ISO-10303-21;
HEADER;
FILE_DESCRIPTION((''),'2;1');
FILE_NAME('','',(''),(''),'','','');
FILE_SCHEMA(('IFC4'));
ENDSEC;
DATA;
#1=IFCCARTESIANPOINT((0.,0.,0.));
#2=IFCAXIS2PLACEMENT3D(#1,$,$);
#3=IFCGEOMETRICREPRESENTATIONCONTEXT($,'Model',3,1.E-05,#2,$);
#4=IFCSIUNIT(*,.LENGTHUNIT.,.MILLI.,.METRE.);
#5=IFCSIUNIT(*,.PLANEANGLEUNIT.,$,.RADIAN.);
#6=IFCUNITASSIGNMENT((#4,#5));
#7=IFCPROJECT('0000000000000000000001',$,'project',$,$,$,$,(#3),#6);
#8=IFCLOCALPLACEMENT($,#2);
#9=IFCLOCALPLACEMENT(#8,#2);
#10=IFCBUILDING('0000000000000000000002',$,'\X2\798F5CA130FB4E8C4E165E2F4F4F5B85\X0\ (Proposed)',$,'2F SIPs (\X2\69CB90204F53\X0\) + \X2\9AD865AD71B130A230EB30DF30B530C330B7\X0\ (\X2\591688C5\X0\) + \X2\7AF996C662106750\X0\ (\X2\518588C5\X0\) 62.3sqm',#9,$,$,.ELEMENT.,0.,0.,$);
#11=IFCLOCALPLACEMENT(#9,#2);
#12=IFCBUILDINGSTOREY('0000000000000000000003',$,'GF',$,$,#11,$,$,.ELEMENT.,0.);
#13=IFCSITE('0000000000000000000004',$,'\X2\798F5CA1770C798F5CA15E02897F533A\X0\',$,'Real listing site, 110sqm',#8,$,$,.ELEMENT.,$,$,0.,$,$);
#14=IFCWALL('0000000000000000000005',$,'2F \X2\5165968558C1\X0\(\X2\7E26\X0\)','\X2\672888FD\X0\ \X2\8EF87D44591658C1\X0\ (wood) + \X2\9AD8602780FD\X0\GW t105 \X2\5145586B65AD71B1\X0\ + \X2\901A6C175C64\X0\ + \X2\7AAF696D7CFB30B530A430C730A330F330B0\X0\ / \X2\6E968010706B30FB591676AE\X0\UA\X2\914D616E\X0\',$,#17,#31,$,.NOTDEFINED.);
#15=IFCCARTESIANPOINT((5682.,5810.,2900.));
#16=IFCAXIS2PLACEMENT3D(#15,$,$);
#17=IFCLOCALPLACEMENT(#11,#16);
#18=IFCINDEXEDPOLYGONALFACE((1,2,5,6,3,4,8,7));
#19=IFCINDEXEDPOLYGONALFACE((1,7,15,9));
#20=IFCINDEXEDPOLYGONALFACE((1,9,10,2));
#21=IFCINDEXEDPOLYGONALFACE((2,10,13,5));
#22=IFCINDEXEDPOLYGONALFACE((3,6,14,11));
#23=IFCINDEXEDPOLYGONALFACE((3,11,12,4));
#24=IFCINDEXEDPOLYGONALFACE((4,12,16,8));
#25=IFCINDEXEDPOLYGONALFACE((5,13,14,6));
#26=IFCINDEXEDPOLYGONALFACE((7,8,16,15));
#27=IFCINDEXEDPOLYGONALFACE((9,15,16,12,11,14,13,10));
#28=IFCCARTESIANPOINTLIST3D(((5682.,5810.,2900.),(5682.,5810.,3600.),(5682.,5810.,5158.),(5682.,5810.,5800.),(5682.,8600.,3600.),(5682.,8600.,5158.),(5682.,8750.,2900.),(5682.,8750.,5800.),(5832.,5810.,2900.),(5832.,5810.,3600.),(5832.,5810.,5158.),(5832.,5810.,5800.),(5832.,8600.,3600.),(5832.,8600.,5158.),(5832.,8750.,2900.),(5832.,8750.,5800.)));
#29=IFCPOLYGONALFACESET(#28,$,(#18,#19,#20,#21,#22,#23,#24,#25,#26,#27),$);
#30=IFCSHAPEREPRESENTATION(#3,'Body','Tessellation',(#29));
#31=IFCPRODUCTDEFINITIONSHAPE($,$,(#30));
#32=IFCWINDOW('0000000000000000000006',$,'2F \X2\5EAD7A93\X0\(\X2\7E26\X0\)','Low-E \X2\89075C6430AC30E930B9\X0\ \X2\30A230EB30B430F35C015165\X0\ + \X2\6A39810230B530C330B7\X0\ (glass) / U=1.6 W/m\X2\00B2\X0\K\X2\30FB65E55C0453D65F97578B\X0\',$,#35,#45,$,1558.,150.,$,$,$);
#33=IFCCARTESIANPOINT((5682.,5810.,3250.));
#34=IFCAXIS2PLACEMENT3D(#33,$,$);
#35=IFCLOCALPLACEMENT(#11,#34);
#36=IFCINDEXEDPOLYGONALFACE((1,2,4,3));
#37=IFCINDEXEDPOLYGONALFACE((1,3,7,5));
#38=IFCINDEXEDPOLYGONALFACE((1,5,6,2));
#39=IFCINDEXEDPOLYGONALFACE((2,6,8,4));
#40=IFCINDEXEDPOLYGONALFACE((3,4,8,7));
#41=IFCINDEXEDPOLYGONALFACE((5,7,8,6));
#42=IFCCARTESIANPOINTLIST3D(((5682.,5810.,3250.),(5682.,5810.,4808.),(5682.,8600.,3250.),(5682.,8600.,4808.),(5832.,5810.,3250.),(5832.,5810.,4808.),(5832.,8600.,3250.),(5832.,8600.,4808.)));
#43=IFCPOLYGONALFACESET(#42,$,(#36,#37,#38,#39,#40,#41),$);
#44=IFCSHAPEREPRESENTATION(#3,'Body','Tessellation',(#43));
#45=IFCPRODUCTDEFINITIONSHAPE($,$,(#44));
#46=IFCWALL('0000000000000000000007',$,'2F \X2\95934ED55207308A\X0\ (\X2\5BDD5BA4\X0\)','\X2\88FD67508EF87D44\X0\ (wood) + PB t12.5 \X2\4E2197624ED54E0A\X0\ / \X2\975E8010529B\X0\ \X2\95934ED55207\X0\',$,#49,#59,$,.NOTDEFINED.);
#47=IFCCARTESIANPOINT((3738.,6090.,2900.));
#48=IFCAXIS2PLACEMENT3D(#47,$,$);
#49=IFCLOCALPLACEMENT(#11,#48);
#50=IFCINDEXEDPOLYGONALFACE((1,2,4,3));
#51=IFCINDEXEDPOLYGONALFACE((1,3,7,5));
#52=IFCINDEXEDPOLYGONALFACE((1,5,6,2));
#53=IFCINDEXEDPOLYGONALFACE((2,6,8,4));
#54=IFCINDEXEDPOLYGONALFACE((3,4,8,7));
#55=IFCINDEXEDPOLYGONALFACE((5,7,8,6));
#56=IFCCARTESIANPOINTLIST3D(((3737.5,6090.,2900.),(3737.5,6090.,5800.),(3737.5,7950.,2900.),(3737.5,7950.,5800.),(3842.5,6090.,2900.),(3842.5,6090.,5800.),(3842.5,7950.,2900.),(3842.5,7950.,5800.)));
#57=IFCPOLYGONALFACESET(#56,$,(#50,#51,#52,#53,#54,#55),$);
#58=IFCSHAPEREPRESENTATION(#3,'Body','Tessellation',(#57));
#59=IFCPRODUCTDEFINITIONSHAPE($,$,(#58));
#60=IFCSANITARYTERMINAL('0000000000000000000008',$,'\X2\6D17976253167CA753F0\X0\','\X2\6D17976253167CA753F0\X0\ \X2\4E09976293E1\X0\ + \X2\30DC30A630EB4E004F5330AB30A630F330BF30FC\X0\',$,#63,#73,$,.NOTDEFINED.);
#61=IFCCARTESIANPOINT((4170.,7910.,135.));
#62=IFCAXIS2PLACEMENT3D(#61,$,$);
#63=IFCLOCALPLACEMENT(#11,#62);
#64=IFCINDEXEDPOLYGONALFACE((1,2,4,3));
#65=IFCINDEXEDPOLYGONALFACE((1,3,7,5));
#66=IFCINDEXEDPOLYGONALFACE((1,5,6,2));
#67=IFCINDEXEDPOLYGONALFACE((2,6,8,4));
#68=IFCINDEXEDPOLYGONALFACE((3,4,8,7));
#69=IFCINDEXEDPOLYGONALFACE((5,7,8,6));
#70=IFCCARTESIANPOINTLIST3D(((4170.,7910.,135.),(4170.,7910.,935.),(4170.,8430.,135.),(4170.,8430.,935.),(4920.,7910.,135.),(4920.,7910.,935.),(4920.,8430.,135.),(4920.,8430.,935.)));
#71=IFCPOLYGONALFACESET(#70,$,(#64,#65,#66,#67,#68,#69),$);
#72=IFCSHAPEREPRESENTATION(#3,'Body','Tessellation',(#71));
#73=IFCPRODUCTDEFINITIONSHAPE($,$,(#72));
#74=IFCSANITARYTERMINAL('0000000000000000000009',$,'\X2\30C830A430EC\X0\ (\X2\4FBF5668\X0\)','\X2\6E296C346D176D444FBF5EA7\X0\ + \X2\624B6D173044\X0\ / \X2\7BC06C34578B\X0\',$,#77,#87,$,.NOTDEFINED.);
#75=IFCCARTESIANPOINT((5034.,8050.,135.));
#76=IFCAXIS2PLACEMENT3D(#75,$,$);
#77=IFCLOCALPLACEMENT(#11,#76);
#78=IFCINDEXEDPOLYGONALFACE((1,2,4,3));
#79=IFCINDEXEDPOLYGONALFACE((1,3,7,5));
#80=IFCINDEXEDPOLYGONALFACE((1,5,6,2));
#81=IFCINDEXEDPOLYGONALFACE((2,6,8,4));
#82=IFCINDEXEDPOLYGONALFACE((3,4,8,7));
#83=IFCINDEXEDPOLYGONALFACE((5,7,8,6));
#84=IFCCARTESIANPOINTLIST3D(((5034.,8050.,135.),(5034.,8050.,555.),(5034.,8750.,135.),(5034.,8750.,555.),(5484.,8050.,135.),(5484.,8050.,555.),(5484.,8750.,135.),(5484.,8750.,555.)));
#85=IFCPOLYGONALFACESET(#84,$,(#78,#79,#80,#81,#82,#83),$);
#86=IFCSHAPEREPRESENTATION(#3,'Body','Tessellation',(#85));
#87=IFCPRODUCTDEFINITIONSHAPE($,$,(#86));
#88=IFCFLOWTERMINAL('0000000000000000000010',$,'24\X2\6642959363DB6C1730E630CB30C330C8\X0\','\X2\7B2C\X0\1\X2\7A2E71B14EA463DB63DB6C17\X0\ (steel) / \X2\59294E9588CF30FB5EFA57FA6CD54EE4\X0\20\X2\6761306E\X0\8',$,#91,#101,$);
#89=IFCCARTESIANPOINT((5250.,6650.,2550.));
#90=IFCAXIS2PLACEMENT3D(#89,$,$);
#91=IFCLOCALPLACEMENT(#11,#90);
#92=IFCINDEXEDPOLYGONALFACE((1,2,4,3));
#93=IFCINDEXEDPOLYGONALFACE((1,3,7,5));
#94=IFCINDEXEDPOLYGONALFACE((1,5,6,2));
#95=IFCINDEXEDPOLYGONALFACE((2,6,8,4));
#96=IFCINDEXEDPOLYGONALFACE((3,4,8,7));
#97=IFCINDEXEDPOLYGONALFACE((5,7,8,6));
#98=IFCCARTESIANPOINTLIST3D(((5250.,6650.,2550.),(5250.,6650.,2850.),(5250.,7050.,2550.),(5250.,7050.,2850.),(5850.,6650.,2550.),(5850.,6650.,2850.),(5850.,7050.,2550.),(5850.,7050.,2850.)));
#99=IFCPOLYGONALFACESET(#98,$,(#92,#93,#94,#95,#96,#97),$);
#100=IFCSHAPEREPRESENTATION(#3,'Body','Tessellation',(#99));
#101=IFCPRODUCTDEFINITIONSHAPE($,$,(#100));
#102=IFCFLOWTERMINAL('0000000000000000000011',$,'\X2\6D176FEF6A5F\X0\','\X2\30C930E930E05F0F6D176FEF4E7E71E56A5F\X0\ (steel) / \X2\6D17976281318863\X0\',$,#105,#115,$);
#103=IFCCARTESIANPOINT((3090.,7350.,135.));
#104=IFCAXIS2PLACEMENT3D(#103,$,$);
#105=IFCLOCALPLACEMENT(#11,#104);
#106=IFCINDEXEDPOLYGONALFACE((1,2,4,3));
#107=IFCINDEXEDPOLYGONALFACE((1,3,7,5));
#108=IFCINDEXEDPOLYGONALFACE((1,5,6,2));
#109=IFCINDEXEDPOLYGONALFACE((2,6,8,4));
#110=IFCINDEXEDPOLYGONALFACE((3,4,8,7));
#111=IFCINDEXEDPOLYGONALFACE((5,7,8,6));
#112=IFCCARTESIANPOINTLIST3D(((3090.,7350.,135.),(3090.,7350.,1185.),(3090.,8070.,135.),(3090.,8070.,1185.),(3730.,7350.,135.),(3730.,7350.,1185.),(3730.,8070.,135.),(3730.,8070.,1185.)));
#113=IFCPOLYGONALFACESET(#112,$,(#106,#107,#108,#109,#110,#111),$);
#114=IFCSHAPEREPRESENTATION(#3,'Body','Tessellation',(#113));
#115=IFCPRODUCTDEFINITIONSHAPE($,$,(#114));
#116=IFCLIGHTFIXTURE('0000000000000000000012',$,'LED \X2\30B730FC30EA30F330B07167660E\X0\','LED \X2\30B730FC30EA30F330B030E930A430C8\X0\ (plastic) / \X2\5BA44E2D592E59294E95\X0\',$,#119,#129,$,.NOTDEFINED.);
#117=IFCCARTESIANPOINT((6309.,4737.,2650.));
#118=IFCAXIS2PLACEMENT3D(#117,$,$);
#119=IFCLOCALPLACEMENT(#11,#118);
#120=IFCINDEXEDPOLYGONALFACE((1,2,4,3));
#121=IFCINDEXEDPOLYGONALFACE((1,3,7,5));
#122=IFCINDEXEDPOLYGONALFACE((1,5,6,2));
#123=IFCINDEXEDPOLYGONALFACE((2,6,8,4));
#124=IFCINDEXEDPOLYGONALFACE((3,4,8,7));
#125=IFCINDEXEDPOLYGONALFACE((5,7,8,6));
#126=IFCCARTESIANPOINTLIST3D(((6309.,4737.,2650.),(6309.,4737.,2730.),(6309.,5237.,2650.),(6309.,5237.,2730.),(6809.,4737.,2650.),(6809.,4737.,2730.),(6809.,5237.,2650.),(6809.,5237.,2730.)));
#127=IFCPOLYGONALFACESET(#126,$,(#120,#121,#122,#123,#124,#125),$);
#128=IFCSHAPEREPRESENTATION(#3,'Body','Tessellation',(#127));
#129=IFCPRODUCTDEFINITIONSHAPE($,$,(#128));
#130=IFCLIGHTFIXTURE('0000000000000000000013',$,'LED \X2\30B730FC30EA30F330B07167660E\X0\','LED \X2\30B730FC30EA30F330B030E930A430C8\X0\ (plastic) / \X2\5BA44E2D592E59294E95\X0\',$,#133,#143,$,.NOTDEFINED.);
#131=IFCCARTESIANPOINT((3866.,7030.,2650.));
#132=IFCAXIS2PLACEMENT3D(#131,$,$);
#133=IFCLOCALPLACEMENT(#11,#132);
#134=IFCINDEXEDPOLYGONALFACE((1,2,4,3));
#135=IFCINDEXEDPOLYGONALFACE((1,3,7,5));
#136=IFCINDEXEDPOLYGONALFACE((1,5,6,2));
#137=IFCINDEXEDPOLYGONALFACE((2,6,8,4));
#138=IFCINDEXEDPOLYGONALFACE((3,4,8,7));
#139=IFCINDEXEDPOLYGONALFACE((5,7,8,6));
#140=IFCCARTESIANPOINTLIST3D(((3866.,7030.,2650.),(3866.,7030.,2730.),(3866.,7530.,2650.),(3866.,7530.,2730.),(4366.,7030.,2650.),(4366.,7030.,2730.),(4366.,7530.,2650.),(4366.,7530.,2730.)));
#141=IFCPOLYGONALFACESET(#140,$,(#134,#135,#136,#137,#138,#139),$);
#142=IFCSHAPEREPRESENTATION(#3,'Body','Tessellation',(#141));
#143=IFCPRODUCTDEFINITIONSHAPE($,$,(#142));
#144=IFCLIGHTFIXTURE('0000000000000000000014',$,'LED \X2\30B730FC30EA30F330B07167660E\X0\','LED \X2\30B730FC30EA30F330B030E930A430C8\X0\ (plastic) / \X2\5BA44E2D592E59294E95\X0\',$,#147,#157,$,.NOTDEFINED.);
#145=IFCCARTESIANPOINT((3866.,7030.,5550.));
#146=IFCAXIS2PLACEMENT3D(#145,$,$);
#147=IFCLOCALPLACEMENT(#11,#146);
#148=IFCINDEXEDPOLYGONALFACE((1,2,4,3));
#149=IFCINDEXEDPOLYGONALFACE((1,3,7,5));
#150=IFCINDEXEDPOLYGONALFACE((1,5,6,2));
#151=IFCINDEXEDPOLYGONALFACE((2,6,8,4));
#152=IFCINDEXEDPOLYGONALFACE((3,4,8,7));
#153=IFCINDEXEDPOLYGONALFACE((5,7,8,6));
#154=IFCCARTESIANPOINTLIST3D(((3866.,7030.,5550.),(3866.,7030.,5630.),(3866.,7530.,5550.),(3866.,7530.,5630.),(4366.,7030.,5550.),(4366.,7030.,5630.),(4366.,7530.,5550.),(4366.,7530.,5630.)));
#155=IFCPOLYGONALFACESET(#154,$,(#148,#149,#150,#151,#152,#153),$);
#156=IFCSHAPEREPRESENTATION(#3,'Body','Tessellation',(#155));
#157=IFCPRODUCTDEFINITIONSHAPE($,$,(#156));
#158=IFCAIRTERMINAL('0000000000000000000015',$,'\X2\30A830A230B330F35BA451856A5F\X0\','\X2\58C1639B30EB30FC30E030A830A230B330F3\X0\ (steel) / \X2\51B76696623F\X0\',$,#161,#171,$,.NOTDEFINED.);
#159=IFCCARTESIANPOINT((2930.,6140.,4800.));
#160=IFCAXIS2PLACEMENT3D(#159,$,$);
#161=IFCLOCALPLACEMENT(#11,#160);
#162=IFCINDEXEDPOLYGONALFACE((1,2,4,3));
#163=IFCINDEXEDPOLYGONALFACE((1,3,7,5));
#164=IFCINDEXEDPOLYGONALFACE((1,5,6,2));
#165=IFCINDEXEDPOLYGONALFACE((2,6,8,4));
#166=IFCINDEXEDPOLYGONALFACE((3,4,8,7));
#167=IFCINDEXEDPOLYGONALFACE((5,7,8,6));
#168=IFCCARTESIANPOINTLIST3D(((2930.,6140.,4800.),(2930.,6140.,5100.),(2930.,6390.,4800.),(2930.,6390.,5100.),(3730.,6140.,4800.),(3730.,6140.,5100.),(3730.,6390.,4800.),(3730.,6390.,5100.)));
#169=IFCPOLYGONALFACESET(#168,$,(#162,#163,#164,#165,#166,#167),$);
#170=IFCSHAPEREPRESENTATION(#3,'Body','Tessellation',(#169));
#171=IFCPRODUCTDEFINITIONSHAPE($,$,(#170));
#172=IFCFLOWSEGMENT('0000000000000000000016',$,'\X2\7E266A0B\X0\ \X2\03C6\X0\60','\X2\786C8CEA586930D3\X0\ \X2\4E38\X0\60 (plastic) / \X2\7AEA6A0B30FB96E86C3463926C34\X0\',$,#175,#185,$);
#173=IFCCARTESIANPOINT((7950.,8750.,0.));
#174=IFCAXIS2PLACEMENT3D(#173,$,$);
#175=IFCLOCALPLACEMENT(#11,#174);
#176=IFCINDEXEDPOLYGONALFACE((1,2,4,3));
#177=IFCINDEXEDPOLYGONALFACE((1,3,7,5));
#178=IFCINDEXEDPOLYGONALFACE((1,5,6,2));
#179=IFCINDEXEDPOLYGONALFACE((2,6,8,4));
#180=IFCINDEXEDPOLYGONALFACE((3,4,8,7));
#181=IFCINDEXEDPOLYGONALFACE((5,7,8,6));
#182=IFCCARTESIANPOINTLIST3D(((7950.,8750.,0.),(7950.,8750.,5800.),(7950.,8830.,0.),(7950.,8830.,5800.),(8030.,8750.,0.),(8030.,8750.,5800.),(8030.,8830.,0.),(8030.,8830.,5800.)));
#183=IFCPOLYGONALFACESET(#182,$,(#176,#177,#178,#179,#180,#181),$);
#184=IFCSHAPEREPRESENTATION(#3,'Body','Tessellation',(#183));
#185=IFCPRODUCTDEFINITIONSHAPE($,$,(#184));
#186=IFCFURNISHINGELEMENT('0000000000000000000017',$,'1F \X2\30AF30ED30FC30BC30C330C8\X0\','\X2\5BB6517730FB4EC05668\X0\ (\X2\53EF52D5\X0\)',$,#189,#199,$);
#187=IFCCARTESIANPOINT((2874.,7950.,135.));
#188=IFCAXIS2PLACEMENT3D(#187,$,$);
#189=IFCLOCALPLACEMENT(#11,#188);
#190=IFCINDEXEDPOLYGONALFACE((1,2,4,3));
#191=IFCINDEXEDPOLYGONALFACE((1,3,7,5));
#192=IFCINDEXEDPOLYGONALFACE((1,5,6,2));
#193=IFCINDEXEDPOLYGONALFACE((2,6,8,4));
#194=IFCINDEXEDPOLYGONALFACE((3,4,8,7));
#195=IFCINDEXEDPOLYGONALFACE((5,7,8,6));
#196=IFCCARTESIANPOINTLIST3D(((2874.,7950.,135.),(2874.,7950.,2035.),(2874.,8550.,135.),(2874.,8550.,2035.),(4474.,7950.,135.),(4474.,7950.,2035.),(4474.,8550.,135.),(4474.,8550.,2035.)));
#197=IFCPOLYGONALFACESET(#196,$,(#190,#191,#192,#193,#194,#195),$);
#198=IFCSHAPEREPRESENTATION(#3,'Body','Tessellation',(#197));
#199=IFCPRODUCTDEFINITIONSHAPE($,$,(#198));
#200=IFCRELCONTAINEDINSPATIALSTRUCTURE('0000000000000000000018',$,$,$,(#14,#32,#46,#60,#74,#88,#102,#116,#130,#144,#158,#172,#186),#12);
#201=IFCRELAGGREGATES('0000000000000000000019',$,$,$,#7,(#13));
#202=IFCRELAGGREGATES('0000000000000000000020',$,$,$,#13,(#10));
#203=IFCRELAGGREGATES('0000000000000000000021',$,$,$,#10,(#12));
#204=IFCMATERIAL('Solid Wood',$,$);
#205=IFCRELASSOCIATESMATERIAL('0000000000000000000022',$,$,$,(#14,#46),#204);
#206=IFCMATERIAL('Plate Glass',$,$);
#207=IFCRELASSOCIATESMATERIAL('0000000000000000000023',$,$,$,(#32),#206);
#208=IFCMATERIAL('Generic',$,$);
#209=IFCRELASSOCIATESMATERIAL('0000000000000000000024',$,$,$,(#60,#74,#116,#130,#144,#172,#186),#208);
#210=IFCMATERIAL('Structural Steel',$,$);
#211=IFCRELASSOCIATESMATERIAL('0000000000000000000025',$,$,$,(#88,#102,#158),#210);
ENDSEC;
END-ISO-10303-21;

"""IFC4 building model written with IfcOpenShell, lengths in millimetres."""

from ifc_helpers import new_model, si_unit, frame, frame_2d, origin, place, context, project, spatial, rectangle, extrude, material, element, fill, save


model = new_model("IFC4")

# Units and contexts
model_context = context("Model", 3, precision=1e-05, world=origin())
ifc_project = project(units=[si_unit("LENGTHUNIT", "METRE", prefix="MILLI"), si_unit("PLANEANGLEUNIT", "RADIAN")], contexts=[model_context])

# Site, building, storey
site_placement = place(None, origin())
site = spatial("IfcSite", under=ifc_project, at=site_placement, Name="福岡県福岡市西区", ObjectType="Real listing site, 110sqm", CompositionType="ELEMENT", RefElevation=0.0)
building_placement = place(site_placement, origin())
building = spatial("IfcBuilding", under=site, at=building_placement, Name="福岡・二世帯住宅 (Proposed)", ObjectType="2F SIPs (構造体) + 高断熱アルミサッシ (外装) + 竹集成材 (内装) 62.3sqm", CompositionType="ELEMENT", ElevationOfRefHeight=0.0, ElevationOfTerrain=0.0)
storey_placement = place(building_placement, origin())
storey = spatial("IfcBuildingStorey", under=building, at=storey_placement, Name="GF", CompositionType="ELEMENT", Elevation=0.0)

# Shared definitions
ifc_material_1 = material(Name="Solid Wood")

# Shared definitions
ifc_material_2 = material(Name="Plate Glass")

# Wall, opening, window
wall_1_placement = place(storey_placement, frame((5682.0, 5810.0, 2900.0)))
wall_1 = element("IfcWall", 1, at=wall_1_placement, inside=storey, material=ifc_material_1, Name="2F 入隅壁(縦)", Description="木製 軸組外壁 (wood) + 高性能GW t105 充填断熱 + 通気層 + 窯業系サイディング / 準耐火・外皮UA配慮", PredefinedType="NOTDEFINED", context=model_context, shape_type="SweptSolid", body=[
    extrude(rectangle(XDim=150.0, YDim=2940.0, at=frame_2d((75.0, 1470.0))), frame((5682.0, 5810.0, 2900.0)), (0.0, 0.0, 1.0), 2900.0),
])
opening_1_placement = place(storey_placement, frame((5682.0, 5810.0, 3250.0)))
opening_1 = element("IfcOpeningElement", 2, at=opening_1_placement, cuts=wall_1, PredefinedType="NOTDEFINED", context=model_context, shape_type="SweptSolid", body=[
    extrude(rectangle(XDim=150.0, YDim=2790.0, at=frame_2d((75.0, 1395.0))), frame((5682.0, 5810.0, 3250.0)), (0.0, 0.0, 1.0), 1558.0),
])
window_1_placement = place(storey_placement, frame((5682.0, 5810.0, 3250.0)))
window_1 = element("IfcWindow", 3, at=window_1_placement, inside=storey, material=ifc_material_2, Name="2F 庭窓(縦)", Description="Low-E 複層ガラス アルゴン封入 + 樹脂サッシ (glass) / U=1.6 W/m²K・日射取得型", OverallHeight=1558.0, OverallWidth=150.0, context=model_context, shape_type="SweptSolid", body=[
    extrude(rectangle(XDim=150.0, YDim=2790.0, at=frame_2d((75.0, 1395.0))), frame((5682.0, 5810.0, 3250.0)), (0.0, 0.0, 1.0), 1558.0),
])
fill(opening_1, window_1)

# Wall
wall_2_placement = place(storey_placement, frame((3738.0, 6090.0, 2900.0)))
element("IfcWall", 4, at=wall_2_placement, inside=storey, material=ifc_material_1, Name="2F 間仕切り (寝室)", Description="製材軸組 (wood) + PB t12.5 両面仕上 / 非耐力 間仕切", PredefinedType="NOTDEFINED", context=model_context, shape_type="SweptSolid", body=[
    extrude(rectangle(XDim=105.0, YDim=1860.0, at=frame_2d((52.0, 930.0))), frame((3738.0, 6090.0, 2900.0)), (0.0, 0.0, 1.0), 2900.0),
])

# Sanitary terminals
ifc_material_3 = material(Name="Generic")
sanitary_terminal_1_placement = place(storey_placement, frame((4170.0, 7910.0, 135.0)))
element("IfcSanitaryTerminal", 5, at=sanitary_terminal_1_placement, inside=storey, material=ifc_material_3, Name="洗面化粧台", Description="洗面化粧台 三面鏡 + ボウル一体カウンター", PredefinedType="NOTDEFINED", context=model_context, shape_type="SweptSolid", body=[
    extrude(rectangle(XDim=750.0, YDim=520.0, at=frame_2d((375.0, 260.0))), frame((4170.0, 7910.0, 135.0)), (0.0, 0.0, 1.0), 800.0),
])
sanitary_terminal_2_placement = place(storey_placement, frame((5034.0, 8050.0, 135.0)))
element("IfcSanitaryTerminal", 6, at=sanitary_terminal_2_placement, inside=storey, material=ifc_material_3, Name="トイレ (便器)", Description="温水洗浄便座 + 手洗い / 節水型", PredefinedType="NOTDEFINED", context=model_context, shape_type="SweptSolid", body=[
    extrude(rectangle(XDim=450.0, YDim=700.0, at=frame_2d((225.0, 350.0))), frame((5034.0, 8050.0, 135.0)), (0.0, 0.0, 1.0), 420.0),
])

# Flow terminals
ifc_material_4 = material(Name="Structural Steel")
flow_terminal_1_placement = place(storey_placement, frame((5250.0, 6650.0, 2550.0)))
element("IfcFlowTerminal", 7, at=flow_terminal_1_placement, inside=storey, material=ifc_material_4, Name="24時間換気ユニット", Description="第1種熱交換換気 (steel) / 天井裏・建基法令20条の8", context=model_context, shape_type="SweptSolid", body=[
    extrude(rectangle(XDim=600.0, YDim=400.0, at=frame_2d((300.0, 200.0))), frame((5250.0, 6650.0, 2550.0)), (0.0, 0.0, 1.0), 300.0),
])
flow_terminal_2_placement = place(storey_placement, frame((3090.0, 7350.0, 135.0)))
element("IfcFlowTerminal", 8, at=flow_terminal_2_placement, inside=storey, material=ifc_material_4, Name="洗濯機", Description="ドラム式洗濯乾燥機 (steel) / 洗面脱衣", context=model_context, shape_type="SweptSolid", body=[
    extrude(rectangle(XDim=640.0, YDim=720.0, at=frame_2d((320.0, 360.0))), frame((3090.0, 7350.0, 135.0)), (0.0, 0.0, 1.0), 1050.0),
])

# Light fixtures
light_fixture_1_placement = place(storey_placement, frame((6309.0, 4737.0, 2650.0)))
element("IfcLightFixture", 9, at=light_fixture_1_placement, inside=storey, material=ifc_material_3, Name="LED シーリング照明", Description="LED シーリングライト (plastic) / 室中央天井", PredefinedType="NOTDEFINED", context=model_context, shape_type="SweptSolid", body=[
    extrude(rectangle(XDim=500.0, YDim=500.0, at=frame_2d((250.0, 250.0))), frame((6309.0, 4737.0, 2650.0)), (0.0, 0.0, 1.0), 80.0),
])
light_fixture_2_placement = place(storey_placement, frame((3866.0, 7030.0, 2650.0)))
element("IfcLightFixture", 10, at=light_fixture_2_placement, inside=storey, material=ifc_material_3, Name="LED シーリング照明", Description="LED シーリングライト (plastic) / 室中央天井", PredefinedType="NOTDEFINED", context=model_context, shape_type="SweptSolid", body=[
    extrude(rectangle(XDim=500.0, YDim=500.0, at=frame_2d((250.0, 250.0))), frame((3866.0, 7030.0, 2650.0)), (0.0, 0.0, 1.0), 80.0),
])
light_fixture_3_placement = place(storey_placement, frame((3866.0, 7030.0, 5550.0)))
element("IfcLightFixture", 11, at=light_fixture_3_placement, inside=storey, material=ifc_material_3, Name="LED シーリング照明", Description="LED シーリングライト (plastic) / 室中央天井", PredefinedType="NOTDEFINED", context=model_context, shape_type="SweptSolid", body=[
    extrude(rectangle(XDim=500.0, YDim=500.0, at=frame_2d((250.0, 250.0))), frame((3866.0, 7030.0, 5550.0)), (0.0, 0.0, 1.0), 80.0),
])

# Air terminal
air_terminal_placement = place(storey_placement, frame((2930.0, 6140.0, 4800.0)))
element("IfcAirTerminal", 12, at=air_terminal_placement, inside=storey, material=ifc_material_4, Name="エアコン室内機", Description="壁掛ルームエアコン (steel) / 冷暖房", PredefinedType="NOTDEFINED", context=model_context, shape_type="SweptSolid", body=[
    extrude(rectangle(XDim=800.0, YDim=250.0, at=frame_2d((400.0, 125.0))), frame((2930.0, 6140.0, 4800.0)), (0.0, 0.0, 1.0), 300.0),
])

# Flow segment
flow_segment_placement = place(storey_placement, frame((7950.0, 8750.0, 0.0)))
element("IfcFlowSegment", 13, at=flow_segment_placement, inside=storey, material=ifc_material_3, Name="縦樋 φ60", Description="硬質塩ビ 丸60 (plastic) / 竪樋・雨水排水", context=model_context, shape_type="SweptSolid", body=[
    extrude(rectangle(XDim=80.0, YDim=80.0, at=frame_2d((40.0, 40.0))), frame((7950.0, 8750.0, 0.0)), (0.0, 0.0, 1.0), 5800.0),
])

# Furnishing element
furnishing_1_placement = place(storey_placement, frame((2874.0, 7950.0, 135.0)))
element("IfcFurnishingElement", 14, at=furnishing_1_placement, inside=storey, material=ifc_material_3, Name="1F クローゼット", Description="家具・什器 (可動)", context=model_context, shape_type="SweptSolid", body=[
    extrude(rectangle(XDim=1600.0, YDim=600.0, at=frame_2d((800.0, 300.0))), frame((2874.0, 7950.0, 135.0)), (0.0, 0.0, 1.0), 1900.0),
])

save(model, "model.ifc")
